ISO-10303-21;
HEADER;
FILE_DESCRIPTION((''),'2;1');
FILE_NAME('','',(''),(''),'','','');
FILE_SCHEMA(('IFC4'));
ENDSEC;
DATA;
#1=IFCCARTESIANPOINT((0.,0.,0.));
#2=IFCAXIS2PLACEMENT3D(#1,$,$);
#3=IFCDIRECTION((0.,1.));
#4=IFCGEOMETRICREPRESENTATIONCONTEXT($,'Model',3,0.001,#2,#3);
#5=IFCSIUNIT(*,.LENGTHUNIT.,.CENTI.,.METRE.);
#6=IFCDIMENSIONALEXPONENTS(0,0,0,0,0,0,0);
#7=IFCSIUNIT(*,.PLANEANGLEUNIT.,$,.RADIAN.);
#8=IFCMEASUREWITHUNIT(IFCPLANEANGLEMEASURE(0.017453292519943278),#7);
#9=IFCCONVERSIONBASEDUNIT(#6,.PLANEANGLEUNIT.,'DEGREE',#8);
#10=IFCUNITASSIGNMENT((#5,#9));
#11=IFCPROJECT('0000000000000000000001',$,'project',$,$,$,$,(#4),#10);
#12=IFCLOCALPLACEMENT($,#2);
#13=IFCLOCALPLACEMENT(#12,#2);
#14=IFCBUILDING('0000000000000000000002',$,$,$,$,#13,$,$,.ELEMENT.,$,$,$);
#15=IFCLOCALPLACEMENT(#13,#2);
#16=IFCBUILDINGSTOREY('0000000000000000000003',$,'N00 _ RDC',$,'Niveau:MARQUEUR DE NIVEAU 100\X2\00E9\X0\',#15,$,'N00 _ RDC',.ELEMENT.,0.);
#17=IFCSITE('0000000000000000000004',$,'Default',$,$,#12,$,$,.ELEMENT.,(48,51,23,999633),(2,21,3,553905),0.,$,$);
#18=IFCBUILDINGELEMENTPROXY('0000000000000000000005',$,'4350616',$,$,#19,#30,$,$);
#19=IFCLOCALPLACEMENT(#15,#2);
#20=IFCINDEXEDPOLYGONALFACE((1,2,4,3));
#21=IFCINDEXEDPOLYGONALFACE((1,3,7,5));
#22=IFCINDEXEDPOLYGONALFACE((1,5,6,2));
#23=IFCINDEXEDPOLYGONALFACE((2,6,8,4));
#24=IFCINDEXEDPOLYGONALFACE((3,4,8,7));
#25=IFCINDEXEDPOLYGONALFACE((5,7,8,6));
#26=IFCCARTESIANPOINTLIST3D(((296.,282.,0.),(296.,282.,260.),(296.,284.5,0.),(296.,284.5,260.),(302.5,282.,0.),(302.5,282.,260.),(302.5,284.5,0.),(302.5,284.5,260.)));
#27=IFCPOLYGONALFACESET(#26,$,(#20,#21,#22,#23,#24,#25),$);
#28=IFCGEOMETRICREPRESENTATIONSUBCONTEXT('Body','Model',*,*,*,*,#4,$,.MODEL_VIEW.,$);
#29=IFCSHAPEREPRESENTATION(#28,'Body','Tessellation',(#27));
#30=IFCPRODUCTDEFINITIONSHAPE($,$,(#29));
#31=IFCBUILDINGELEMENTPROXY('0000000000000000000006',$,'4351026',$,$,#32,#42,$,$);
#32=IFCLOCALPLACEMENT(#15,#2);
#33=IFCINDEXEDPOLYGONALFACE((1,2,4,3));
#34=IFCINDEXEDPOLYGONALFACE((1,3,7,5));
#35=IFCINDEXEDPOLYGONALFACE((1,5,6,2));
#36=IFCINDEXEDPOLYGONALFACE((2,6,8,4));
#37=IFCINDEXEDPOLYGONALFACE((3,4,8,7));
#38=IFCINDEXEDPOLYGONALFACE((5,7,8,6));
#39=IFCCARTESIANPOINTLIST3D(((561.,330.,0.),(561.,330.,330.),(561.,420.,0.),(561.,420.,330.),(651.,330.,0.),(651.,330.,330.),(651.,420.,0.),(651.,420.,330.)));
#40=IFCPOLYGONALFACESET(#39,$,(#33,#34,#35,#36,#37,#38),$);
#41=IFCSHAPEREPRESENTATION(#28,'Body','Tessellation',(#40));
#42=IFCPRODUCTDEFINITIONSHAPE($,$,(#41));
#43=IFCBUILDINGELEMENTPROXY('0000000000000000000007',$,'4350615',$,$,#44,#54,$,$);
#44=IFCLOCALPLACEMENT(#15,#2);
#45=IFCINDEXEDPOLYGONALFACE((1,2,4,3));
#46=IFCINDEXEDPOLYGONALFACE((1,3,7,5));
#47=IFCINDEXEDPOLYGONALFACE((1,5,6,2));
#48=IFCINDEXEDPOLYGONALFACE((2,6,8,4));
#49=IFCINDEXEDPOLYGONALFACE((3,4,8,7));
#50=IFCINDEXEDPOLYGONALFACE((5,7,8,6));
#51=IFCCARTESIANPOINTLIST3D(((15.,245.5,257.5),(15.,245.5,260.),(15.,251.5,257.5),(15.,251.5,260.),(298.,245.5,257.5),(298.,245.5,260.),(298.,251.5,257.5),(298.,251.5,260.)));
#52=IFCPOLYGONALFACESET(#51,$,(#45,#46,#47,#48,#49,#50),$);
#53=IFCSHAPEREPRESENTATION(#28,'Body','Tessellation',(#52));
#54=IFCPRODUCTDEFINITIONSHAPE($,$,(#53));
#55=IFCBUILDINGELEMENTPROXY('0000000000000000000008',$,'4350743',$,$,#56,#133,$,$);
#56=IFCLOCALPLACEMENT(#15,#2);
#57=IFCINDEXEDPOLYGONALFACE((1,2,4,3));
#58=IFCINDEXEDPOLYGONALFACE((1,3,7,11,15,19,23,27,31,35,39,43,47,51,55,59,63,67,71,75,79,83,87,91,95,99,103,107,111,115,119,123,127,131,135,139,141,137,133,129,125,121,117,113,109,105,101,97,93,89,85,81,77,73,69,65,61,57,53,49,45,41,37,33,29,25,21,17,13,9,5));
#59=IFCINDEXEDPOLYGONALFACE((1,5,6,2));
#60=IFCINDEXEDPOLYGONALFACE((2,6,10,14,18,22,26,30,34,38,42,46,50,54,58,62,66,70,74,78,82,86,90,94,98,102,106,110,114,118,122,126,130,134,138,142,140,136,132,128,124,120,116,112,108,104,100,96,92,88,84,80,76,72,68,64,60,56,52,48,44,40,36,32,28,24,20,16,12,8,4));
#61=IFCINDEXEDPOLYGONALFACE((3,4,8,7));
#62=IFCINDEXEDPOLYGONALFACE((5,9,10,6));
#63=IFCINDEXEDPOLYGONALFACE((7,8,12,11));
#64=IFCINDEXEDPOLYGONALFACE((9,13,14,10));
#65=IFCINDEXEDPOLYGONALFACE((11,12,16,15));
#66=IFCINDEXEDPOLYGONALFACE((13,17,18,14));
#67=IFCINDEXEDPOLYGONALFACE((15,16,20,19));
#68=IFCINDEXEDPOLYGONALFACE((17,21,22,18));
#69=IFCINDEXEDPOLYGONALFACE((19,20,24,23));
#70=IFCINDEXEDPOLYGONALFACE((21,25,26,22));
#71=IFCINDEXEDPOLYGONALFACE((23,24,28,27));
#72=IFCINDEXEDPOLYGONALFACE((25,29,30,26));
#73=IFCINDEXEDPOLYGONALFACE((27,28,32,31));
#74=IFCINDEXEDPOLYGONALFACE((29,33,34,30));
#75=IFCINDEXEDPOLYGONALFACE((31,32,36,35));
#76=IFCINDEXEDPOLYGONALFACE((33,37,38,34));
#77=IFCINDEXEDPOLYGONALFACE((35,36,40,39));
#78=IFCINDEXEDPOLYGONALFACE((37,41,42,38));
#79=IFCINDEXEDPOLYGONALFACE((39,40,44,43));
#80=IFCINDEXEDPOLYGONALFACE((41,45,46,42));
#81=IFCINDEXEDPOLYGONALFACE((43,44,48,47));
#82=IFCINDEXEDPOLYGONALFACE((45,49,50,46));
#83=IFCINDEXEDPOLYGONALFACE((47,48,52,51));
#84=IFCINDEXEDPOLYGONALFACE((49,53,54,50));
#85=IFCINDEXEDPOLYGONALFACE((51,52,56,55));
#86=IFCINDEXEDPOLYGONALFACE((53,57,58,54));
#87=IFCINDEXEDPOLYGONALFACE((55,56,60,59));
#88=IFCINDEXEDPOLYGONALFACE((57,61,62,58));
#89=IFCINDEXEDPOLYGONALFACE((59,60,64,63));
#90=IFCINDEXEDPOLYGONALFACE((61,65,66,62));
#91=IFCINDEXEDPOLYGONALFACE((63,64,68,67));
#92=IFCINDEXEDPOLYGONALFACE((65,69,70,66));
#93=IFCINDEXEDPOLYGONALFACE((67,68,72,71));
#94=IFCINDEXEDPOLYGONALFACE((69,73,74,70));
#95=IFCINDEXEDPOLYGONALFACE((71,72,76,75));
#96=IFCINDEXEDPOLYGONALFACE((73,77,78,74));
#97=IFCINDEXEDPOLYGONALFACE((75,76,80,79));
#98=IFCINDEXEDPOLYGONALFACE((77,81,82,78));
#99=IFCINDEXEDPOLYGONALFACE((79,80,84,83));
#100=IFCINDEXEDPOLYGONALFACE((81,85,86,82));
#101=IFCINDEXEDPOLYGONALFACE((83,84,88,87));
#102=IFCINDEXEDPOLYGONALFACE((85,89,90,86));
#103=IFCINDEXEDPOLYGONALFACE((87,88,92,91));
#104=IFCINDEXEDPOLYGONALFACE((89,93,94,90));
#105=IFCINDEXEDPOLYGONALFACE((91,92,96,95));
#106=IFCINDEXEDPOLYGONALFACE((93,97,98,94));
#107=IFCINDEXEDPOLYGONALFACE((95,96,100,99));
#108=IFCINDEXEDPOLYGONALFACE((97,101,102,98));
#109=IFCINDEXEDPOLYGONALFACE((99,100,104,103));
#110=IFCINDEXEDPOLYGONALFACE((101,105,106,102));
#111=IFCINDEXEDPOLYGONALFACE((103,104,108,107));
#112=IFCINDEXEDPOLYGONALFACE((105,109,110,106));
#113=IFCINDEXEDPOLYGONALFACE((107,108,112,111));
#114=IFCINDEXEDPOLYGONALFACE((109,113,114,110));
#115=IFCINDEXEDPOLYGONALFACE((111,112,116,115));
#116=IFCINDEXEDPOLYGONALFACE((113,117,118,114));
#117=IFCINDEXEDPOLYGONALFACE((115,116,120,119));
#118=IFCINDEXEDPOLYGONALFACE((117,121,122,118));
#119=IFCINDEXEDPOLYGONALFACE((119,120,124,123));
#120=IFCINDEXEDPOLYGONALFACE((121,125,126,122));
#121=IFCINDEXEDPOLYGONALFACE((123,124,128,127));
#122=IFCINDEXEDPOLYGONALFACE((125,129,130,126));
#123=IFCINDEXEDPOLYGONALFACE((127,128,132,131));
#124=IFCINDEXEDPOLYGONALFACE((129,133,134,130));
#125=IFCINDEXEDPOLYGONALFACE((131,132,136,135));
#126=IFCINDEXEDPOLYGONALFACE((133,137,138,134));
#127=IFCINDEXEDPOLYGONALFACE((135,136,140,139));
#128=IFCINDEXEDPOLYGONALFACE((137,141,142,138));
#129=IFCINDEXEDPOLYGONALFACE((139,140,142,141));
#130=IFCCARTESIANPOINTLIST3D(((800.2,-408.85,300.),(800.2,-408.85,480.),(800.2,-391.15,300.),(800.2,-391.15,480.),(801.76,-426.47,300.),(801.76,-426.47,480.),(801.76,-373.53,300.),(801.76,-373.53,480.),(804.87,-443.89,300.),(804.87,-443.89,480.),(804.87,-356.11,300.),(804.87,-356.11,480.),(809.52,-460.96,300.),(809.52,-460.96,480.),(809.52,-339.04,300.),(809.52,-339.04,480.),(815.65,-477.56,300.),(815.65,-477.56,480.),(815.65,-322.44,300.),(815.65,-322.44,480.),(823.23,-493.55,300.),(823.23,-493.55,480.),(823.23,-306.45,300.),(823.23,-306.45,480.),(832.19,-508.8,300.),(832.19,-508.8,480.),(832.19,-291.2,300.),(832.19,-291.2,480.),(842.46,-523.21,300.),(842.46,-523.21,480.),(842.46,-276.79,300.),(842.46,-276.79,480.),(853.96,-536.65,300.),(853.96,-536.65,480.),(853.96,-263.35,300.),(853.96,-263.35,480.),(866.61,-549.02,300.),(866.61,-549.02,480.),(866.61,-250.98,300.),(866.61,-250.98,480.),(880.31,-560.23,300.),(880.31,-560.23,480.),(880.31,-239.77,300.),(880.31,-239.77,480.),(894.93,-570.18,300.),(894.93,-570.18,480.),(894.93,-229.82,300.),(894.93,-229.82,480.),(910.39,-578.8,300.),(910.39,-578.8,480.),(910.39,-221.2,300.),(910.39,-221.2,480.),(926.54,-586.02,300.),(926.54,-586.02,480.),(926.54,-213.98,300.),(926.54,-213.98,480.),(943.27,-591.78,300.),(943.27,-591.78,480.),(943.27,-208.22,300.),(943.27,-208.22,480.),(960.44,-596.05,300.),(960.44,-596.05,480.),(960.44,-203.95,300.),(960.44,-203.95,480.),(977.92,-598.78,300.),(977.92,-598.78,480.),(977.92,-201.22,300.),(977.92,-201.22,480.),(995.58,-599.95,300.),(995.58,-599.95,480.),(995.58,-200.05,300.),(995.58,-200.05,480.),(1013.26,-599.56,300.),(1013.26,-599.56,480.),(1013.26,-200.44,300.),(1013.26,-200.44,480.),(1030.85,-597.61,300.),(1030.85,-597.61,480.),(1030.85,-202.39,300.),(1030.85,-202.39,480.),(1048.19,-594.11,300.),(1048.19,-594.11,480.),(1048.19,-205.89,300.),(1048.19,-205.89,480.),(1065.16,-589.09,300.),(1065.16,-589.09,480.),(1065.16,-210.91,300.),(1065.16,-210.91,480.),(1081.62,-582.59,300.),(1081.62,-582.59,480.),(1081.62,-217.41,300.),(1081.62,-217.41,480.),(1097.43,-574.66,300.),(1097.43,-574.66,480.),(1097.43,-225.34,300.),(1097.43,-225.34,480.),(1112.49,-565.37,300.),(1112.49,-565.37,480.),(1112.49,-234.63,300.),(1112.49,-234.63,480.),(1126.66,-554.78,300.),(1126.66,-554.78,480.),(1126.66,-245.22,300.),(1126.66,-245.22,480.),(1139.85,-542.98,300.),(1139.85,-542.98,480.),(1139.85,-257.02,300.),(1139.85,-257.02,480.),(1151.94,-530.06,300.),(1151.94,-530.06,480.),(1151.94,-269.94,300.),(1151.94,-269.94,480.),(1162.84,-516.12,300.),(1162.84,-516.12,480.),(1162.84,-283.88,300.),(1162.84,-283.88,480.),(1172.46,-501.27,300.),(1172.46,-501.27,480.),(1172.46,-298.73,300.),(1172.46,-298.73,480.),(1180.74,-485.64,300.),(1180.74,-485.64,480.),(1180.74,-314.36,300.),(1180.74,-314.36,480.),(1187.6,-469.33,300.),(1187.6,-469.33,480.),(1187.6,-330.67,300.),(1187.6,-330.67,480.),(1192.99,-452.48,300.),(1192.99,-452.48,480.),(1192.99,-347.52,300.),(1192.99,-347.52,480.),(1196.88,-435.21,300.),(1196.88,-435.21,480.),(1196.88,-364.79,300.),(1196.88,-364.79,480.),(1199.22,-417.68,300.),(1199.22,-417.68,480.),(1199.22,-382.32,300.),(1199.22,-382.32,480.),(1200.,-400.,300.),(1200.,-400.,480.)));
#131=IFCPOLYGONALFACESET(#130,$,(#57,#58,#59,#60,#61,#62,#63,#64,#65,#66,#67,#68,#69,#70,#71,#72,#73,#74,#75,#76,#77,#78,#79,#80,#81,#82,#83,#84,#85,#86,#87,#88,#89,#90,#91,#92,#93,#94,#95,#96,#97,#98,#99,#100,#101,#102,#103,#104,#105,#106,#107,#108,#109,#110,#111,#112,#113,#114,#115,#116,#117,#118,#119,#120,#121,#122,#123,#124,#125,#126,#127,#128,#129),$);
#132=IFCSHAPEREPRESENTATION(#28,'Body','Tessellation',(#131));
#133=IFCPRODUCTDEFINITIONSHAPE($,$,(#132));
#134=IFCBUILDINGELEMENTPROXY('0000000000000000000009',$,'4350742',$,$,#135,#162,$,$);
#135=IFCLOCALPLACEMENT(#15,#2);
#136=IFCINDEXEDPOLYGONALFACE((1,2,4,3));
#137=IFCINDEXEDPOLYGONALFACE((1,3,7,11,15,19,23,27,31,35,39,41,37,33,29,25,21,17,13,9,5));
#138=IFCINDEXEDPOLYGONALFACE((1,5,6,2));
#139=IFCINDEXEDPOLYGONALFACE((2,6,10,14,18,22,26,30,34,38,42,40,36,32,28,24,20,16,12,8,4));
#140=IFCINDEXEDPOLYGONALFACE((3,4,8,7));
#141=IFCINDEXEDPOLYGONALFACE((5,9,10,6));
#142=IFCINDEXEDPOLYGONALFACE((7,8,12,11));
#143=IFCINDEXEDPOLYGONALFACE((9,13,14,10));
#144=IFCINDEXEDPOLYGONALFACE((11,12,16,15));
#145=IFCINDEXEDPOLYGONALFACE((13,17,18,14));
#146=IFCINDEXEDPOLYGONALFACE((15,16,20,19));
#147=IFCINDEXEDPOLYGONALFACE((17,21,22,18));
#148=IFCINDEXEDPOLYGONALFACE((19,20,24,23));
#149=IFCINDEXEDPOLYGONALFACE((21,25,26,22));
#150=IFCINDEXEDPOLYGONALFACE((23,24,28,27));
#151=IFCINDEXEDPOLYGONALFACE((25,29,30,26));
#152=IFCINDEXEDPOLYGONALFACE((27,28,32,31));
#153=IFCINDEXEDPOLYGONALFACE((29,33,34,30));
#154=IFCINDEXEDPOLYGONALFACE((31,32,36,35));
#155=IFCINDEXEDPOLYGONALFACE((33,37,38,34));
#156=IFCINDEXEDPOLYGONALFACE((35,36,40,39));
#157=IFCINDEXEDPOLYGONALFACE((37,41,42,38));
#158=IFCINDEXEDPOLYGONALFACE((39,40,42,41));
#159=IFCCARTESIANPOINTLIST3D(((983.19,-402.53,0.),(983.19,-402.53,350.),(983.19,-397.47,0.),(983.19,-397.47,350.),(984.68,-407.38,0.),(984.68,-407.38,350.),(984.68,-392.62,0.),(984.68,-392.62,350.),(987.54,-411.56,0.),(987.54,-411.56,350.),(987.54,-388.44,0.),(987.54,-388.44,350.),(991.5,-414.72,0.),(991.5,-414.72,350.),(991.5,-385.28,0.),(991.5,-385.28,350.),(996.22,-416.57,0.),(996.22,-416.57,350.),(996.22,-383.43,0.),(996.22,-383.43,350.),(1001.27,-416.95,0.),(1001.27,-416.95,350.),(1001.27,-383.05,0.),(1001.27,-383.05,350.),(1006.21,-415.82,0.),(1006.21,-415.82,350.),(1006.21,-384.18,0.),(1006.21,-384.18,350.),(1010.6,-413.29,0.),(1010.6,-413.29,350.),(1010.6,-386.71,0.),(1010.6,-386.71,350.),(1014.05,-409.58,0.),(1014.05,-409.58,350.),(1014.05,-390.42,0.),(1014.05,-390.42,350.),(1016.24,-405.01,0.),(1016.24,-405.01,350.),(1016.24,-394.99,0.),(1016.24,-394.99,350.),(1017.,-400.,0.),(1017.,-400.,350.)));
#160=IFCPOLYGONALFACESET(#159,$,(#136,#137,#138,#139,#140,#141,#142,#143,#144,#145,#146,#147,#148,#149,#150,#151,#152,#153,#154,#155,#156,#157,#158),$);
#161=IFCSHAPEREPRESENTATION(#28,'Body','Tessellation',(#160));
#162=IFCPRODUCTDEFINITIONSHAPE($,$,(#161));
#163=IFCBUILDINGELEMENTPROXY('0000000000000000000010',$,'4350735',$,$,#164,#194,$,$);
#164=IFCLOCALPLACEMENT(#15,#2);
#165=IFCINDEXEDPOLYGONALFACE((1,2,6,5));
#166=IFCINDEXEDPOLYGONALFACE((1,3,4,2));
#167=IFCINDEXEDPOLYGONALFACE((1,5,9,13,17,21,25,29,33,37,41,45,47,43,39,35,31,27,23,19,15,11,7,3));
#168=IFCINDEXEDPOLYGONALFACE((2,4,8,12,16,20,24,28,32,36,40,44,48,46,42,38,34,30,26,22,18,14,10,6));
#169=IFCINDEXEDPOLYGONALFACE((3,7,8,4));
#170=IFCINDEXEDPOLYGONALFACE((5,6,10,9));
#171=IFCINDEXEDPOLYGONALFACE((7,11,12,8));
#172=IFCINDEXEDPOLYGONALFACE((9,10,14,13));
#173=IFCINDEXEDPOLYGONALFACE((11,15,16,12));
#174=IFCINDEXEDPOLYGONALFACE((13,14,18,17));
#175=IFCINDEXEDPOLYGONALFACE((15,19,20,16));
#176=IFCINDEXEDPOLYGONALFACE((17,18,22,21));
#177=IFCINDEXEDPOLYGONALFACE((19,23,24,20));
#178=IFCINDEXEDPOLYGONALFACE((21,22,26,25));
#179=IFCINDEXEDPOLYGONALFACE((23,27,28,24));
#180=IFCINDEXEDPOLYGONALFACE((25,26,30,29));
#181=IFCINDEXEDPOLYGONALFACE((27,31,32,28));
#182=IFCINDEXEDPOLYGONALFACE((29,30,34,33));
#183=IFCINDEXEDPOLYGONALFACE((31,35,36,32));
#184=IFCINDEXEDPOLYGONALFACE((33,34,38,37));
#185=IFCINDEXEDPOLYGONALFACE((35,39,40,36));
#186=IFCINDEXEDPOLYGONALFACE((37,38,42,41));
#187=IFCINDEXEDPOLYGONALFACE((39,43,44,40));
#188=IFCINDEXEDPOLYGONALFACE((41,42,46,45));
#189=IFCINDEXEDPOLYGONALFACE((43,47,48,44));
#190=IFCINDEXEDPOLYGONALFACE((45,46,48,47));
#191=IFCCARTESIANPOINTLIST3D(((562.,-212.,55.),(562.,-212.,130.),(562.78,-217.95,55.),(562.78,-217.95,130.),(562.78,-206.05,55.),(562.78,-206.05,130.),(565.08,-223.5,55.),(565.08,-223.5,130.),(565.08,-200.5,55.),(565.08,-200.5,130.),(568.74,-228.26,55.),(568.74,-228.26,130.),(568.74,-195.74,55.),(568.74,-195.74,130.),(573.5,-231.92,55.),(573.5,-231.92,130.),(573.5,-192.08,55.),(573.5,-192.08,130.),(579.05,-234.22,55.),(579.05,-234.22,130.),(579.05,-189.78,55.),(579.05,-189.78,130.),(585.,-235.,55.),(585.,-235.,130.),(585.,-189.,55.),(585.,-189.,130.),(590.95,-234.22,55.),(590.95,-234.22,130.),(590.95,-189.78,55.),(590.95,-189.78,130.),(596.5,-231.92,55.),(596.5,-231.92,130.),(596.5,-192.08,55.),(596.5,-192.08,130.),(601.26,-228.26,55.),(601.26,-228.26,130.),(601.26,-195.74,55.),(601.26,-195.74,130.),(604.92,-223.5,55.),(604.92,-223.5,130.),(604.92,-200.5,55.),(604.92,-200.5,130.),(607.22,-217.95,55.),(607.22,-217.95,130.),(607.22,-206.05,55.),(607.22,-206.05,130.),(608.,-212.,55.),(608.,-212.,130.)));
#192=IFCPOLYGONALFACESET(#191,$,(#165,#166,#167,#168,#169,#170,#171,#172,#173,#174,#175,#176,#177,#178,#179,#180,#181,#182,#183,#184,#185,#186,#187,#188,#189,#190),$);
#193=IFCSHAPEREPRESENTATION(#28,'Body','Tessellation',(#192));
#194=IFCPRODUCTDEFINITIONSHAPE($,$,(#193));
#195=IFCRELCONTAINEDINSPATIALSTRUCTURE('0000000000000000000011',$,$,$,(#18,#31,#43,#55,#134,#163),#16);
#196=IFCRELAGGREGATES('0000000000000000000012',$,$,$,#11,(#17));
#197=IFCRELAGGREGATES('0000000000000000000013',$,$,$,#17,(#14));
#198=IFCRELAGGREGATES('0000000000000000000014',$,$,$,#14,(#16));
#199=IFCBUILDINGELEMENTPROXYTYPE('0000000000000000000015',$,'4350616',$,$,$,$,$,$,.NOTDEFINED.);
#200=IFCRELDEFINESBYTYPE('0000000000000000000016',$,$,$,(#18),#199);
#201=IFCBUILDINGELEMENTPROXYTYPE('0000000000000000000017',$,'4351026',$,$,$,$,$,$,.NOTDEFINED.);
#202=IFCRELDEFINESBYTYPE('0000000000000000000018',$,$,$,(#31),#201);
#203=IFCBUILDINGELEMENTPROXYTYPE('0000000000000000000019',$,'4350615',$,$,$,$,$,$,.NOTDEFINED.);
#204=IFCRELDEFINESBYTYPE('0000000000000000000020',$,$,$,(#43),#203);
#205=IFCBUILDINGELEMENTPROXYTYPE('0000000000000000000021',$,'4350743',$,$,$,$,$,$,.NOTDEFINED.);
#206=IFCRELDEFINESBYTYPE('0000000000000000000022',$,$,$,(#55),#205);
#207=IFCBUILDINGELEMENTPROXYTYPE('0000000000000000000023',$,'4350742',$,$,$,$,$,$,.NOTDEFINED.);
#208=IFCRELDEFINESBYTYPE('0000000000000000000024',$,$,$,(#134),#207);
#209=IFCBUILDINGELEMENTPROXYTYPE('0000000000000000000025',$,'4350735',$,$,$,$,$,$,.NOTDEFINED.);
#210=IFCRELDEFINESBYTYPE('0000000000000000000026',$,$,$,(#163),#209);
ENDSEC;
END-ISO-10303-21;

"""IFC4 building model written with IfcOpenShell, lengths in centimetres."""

from ifc_helpers import new_model, entity, si_unit, converted_unit, direction, frame, frame_2d, origin, origin_2d_with_axis, place, context, subcontext, project, spatial, rectangle, circle, extrude, type_object, element, save


model = new_model("IFC4")

# Units and contexts
model_context = context("Model", 3, precision=0.001, world=origin(), true_north=direction((0.0, 1.0)))
body_context = subcontext(model_context, "Body", "Model", "MODEL_VIEW")
ifc_project = project(units=[si_unit("LENGTHUNIT", "METRE", prefix="CENTI"), converted_unit("PLANEANGLEUNIT", "DEGREE", entity("IfcPlaneAngleMeasure", 0.017453292519943278), si_unit("PLANEANGLEUNIT", "RADIAN"), dimensions=[0, 0, 0, 0, 0, 0, 0])], contexts=[model_context])

# Site, building, storey
site_placement = place(None, origin())
site = spatial("IfcSite", under=ifc_project, at=site_placement, Name="Default", CompositionType="ELEMENT", RefLatitude=(48, 51, 23, 999633), RefLongitude=(2, 21, 3, 553905), RefElevation=0.0)
building_placement = place(site_placement, origin())
building = spatial("IfcBuilding", under=site, at=building_placement, CompositionType="ELEMENT")
storey_placement = place(building_placement, origin())
storey = spatial("IfcBuildingStorey", under=building, at=storey_placement, Name="N00 _ RDC", ObjectType="Niveau:MARQUEUR DE NIVEAU 100é", LongName="N00 _ RDC", CompositionType="ELEMENT", Elevation=0.0)

# Building element proxies
building_element_proxy_type_1 = type_object("IfcBuildingElementProxyType", Name="4350616", PredefinedType="NOTDEFINED")
proxy_1_placement = place(storey_placement, origin())
element("IfcBuildingElementProxy", 1, at=proxy_1_placement, inside=storey, type_object=building_element_proxy_type_1, Name="4350616", context=body_context, shape_type="SweptSolid", body=[
    extrude(rectangle(XDim=6.5, YDim=2.5, at=frame_2d((0.0, 0.0), x_axis=(1.0, 0.0))), frame((299.25, 283.25, 0.0)), (0.0, 0.0, 1.0), 260.0),
])
building_element_proxy_type_2 = type_object("IfcBuildingElementProxyType", Name="4351026", PredefinedType="NOTDEFINED")
proxy_2_placement = place(storey_placement, origin())
element("IfcBuildingElementProxy", 2, at=proxy_2_placement, inside=storey, type_object=building_element_proxy_type_2, Name="4351026", context=body_context, shape_type="SweptSolid", body=[
    extrude(rectangle(XDim=90.0, YDim=90.0, at=frame_2d((0.0, 0.0), x_axis=(1.0, 0.0))), frame((606.0, 375.0, 0.0)), (0.0, 0.0, 1.0), 330.0),
])
building_element_proxy_type_3 = type_object("IfcBuildingElementProxyType", Name="4350615", PredefinedType="NOTDEFINED")
proxy_3_placement = place(storey_placement, origin())
element("IfcBuildingElementProxy", 3, at=proxy_3_placement, inside=storey, type_object=building_element_proxy_type_3, Name="4350615", context=body_context, shape_type="SweptSolid", body=[
    extrude(rectangle(XDim=283.0, YDim=6.0, at=frame_2d((0.0, 0.0), x_axis=(1.0, 0.0))), frame((156.5, 248.5, 257.5)), (0.0, 0.0, 1.0), 2.5),
])
building_element_proxy_type_4 = type_object("IfcBuildingElementProxyType", Name="4350743", PredefinedType="NOTDEFINED")
proxy_4_placement = place(storey_placement, origin())
element("IfcBuildingElementProxy", 4, at=proxy_4_placement, inside=storey, type_object=building_element_proxy_type_4, Name="4350743", context=body_context, shape_type="SweptSolid", body=[
    extrude(circle(Radius=200.0, at=origin_2d_with_axis()), frame((1000.0, -400.0, 300.0)), (0.0, 0.0, 1.0), 180.0),
])
building_element_proxy_type_5 = type_object("IfcBuildingElementProxyType", Name="4350742", PredefinedType="NOTDEFINED")
proxy_5_placement = place(storey_placement, origin())
element("IfcBuildingElementProxy", 5, at=proxy_5_placement, inside=storey, type_object=building_element_proxy_type_5, Name="4350742", context=body_context, shape_type="SweptSolid", body=[
    extrude(circle(Radius=17.0, at=origin_2d_with_axis()), frame((1000.0, -400.0, 0.0)), (0.0, 0.0, 1.0), 350.0),
])
building_element_proxy_type_6 = type_object("IfcBuildingElementProxyType", Name="4350735", PredefinedType="NOTDEFINED")
proxy_6_placement = place(storey_placement, origin())
element("IfcBuildingElementProxy", 6, at=proxy_6_placement, inside=storey, type_object=building_element_proxy_type_6, Name="4350735", context=body_context, shape_type="SweptSolid", body=[
    extrude(circle(Radius=23.0, at=origin_2d_with_axis()), frame((585.0, -212.0, 55.0)), (0.0, 0.0, 1.0), 75.0),
])

save(model, "model.ifc")
